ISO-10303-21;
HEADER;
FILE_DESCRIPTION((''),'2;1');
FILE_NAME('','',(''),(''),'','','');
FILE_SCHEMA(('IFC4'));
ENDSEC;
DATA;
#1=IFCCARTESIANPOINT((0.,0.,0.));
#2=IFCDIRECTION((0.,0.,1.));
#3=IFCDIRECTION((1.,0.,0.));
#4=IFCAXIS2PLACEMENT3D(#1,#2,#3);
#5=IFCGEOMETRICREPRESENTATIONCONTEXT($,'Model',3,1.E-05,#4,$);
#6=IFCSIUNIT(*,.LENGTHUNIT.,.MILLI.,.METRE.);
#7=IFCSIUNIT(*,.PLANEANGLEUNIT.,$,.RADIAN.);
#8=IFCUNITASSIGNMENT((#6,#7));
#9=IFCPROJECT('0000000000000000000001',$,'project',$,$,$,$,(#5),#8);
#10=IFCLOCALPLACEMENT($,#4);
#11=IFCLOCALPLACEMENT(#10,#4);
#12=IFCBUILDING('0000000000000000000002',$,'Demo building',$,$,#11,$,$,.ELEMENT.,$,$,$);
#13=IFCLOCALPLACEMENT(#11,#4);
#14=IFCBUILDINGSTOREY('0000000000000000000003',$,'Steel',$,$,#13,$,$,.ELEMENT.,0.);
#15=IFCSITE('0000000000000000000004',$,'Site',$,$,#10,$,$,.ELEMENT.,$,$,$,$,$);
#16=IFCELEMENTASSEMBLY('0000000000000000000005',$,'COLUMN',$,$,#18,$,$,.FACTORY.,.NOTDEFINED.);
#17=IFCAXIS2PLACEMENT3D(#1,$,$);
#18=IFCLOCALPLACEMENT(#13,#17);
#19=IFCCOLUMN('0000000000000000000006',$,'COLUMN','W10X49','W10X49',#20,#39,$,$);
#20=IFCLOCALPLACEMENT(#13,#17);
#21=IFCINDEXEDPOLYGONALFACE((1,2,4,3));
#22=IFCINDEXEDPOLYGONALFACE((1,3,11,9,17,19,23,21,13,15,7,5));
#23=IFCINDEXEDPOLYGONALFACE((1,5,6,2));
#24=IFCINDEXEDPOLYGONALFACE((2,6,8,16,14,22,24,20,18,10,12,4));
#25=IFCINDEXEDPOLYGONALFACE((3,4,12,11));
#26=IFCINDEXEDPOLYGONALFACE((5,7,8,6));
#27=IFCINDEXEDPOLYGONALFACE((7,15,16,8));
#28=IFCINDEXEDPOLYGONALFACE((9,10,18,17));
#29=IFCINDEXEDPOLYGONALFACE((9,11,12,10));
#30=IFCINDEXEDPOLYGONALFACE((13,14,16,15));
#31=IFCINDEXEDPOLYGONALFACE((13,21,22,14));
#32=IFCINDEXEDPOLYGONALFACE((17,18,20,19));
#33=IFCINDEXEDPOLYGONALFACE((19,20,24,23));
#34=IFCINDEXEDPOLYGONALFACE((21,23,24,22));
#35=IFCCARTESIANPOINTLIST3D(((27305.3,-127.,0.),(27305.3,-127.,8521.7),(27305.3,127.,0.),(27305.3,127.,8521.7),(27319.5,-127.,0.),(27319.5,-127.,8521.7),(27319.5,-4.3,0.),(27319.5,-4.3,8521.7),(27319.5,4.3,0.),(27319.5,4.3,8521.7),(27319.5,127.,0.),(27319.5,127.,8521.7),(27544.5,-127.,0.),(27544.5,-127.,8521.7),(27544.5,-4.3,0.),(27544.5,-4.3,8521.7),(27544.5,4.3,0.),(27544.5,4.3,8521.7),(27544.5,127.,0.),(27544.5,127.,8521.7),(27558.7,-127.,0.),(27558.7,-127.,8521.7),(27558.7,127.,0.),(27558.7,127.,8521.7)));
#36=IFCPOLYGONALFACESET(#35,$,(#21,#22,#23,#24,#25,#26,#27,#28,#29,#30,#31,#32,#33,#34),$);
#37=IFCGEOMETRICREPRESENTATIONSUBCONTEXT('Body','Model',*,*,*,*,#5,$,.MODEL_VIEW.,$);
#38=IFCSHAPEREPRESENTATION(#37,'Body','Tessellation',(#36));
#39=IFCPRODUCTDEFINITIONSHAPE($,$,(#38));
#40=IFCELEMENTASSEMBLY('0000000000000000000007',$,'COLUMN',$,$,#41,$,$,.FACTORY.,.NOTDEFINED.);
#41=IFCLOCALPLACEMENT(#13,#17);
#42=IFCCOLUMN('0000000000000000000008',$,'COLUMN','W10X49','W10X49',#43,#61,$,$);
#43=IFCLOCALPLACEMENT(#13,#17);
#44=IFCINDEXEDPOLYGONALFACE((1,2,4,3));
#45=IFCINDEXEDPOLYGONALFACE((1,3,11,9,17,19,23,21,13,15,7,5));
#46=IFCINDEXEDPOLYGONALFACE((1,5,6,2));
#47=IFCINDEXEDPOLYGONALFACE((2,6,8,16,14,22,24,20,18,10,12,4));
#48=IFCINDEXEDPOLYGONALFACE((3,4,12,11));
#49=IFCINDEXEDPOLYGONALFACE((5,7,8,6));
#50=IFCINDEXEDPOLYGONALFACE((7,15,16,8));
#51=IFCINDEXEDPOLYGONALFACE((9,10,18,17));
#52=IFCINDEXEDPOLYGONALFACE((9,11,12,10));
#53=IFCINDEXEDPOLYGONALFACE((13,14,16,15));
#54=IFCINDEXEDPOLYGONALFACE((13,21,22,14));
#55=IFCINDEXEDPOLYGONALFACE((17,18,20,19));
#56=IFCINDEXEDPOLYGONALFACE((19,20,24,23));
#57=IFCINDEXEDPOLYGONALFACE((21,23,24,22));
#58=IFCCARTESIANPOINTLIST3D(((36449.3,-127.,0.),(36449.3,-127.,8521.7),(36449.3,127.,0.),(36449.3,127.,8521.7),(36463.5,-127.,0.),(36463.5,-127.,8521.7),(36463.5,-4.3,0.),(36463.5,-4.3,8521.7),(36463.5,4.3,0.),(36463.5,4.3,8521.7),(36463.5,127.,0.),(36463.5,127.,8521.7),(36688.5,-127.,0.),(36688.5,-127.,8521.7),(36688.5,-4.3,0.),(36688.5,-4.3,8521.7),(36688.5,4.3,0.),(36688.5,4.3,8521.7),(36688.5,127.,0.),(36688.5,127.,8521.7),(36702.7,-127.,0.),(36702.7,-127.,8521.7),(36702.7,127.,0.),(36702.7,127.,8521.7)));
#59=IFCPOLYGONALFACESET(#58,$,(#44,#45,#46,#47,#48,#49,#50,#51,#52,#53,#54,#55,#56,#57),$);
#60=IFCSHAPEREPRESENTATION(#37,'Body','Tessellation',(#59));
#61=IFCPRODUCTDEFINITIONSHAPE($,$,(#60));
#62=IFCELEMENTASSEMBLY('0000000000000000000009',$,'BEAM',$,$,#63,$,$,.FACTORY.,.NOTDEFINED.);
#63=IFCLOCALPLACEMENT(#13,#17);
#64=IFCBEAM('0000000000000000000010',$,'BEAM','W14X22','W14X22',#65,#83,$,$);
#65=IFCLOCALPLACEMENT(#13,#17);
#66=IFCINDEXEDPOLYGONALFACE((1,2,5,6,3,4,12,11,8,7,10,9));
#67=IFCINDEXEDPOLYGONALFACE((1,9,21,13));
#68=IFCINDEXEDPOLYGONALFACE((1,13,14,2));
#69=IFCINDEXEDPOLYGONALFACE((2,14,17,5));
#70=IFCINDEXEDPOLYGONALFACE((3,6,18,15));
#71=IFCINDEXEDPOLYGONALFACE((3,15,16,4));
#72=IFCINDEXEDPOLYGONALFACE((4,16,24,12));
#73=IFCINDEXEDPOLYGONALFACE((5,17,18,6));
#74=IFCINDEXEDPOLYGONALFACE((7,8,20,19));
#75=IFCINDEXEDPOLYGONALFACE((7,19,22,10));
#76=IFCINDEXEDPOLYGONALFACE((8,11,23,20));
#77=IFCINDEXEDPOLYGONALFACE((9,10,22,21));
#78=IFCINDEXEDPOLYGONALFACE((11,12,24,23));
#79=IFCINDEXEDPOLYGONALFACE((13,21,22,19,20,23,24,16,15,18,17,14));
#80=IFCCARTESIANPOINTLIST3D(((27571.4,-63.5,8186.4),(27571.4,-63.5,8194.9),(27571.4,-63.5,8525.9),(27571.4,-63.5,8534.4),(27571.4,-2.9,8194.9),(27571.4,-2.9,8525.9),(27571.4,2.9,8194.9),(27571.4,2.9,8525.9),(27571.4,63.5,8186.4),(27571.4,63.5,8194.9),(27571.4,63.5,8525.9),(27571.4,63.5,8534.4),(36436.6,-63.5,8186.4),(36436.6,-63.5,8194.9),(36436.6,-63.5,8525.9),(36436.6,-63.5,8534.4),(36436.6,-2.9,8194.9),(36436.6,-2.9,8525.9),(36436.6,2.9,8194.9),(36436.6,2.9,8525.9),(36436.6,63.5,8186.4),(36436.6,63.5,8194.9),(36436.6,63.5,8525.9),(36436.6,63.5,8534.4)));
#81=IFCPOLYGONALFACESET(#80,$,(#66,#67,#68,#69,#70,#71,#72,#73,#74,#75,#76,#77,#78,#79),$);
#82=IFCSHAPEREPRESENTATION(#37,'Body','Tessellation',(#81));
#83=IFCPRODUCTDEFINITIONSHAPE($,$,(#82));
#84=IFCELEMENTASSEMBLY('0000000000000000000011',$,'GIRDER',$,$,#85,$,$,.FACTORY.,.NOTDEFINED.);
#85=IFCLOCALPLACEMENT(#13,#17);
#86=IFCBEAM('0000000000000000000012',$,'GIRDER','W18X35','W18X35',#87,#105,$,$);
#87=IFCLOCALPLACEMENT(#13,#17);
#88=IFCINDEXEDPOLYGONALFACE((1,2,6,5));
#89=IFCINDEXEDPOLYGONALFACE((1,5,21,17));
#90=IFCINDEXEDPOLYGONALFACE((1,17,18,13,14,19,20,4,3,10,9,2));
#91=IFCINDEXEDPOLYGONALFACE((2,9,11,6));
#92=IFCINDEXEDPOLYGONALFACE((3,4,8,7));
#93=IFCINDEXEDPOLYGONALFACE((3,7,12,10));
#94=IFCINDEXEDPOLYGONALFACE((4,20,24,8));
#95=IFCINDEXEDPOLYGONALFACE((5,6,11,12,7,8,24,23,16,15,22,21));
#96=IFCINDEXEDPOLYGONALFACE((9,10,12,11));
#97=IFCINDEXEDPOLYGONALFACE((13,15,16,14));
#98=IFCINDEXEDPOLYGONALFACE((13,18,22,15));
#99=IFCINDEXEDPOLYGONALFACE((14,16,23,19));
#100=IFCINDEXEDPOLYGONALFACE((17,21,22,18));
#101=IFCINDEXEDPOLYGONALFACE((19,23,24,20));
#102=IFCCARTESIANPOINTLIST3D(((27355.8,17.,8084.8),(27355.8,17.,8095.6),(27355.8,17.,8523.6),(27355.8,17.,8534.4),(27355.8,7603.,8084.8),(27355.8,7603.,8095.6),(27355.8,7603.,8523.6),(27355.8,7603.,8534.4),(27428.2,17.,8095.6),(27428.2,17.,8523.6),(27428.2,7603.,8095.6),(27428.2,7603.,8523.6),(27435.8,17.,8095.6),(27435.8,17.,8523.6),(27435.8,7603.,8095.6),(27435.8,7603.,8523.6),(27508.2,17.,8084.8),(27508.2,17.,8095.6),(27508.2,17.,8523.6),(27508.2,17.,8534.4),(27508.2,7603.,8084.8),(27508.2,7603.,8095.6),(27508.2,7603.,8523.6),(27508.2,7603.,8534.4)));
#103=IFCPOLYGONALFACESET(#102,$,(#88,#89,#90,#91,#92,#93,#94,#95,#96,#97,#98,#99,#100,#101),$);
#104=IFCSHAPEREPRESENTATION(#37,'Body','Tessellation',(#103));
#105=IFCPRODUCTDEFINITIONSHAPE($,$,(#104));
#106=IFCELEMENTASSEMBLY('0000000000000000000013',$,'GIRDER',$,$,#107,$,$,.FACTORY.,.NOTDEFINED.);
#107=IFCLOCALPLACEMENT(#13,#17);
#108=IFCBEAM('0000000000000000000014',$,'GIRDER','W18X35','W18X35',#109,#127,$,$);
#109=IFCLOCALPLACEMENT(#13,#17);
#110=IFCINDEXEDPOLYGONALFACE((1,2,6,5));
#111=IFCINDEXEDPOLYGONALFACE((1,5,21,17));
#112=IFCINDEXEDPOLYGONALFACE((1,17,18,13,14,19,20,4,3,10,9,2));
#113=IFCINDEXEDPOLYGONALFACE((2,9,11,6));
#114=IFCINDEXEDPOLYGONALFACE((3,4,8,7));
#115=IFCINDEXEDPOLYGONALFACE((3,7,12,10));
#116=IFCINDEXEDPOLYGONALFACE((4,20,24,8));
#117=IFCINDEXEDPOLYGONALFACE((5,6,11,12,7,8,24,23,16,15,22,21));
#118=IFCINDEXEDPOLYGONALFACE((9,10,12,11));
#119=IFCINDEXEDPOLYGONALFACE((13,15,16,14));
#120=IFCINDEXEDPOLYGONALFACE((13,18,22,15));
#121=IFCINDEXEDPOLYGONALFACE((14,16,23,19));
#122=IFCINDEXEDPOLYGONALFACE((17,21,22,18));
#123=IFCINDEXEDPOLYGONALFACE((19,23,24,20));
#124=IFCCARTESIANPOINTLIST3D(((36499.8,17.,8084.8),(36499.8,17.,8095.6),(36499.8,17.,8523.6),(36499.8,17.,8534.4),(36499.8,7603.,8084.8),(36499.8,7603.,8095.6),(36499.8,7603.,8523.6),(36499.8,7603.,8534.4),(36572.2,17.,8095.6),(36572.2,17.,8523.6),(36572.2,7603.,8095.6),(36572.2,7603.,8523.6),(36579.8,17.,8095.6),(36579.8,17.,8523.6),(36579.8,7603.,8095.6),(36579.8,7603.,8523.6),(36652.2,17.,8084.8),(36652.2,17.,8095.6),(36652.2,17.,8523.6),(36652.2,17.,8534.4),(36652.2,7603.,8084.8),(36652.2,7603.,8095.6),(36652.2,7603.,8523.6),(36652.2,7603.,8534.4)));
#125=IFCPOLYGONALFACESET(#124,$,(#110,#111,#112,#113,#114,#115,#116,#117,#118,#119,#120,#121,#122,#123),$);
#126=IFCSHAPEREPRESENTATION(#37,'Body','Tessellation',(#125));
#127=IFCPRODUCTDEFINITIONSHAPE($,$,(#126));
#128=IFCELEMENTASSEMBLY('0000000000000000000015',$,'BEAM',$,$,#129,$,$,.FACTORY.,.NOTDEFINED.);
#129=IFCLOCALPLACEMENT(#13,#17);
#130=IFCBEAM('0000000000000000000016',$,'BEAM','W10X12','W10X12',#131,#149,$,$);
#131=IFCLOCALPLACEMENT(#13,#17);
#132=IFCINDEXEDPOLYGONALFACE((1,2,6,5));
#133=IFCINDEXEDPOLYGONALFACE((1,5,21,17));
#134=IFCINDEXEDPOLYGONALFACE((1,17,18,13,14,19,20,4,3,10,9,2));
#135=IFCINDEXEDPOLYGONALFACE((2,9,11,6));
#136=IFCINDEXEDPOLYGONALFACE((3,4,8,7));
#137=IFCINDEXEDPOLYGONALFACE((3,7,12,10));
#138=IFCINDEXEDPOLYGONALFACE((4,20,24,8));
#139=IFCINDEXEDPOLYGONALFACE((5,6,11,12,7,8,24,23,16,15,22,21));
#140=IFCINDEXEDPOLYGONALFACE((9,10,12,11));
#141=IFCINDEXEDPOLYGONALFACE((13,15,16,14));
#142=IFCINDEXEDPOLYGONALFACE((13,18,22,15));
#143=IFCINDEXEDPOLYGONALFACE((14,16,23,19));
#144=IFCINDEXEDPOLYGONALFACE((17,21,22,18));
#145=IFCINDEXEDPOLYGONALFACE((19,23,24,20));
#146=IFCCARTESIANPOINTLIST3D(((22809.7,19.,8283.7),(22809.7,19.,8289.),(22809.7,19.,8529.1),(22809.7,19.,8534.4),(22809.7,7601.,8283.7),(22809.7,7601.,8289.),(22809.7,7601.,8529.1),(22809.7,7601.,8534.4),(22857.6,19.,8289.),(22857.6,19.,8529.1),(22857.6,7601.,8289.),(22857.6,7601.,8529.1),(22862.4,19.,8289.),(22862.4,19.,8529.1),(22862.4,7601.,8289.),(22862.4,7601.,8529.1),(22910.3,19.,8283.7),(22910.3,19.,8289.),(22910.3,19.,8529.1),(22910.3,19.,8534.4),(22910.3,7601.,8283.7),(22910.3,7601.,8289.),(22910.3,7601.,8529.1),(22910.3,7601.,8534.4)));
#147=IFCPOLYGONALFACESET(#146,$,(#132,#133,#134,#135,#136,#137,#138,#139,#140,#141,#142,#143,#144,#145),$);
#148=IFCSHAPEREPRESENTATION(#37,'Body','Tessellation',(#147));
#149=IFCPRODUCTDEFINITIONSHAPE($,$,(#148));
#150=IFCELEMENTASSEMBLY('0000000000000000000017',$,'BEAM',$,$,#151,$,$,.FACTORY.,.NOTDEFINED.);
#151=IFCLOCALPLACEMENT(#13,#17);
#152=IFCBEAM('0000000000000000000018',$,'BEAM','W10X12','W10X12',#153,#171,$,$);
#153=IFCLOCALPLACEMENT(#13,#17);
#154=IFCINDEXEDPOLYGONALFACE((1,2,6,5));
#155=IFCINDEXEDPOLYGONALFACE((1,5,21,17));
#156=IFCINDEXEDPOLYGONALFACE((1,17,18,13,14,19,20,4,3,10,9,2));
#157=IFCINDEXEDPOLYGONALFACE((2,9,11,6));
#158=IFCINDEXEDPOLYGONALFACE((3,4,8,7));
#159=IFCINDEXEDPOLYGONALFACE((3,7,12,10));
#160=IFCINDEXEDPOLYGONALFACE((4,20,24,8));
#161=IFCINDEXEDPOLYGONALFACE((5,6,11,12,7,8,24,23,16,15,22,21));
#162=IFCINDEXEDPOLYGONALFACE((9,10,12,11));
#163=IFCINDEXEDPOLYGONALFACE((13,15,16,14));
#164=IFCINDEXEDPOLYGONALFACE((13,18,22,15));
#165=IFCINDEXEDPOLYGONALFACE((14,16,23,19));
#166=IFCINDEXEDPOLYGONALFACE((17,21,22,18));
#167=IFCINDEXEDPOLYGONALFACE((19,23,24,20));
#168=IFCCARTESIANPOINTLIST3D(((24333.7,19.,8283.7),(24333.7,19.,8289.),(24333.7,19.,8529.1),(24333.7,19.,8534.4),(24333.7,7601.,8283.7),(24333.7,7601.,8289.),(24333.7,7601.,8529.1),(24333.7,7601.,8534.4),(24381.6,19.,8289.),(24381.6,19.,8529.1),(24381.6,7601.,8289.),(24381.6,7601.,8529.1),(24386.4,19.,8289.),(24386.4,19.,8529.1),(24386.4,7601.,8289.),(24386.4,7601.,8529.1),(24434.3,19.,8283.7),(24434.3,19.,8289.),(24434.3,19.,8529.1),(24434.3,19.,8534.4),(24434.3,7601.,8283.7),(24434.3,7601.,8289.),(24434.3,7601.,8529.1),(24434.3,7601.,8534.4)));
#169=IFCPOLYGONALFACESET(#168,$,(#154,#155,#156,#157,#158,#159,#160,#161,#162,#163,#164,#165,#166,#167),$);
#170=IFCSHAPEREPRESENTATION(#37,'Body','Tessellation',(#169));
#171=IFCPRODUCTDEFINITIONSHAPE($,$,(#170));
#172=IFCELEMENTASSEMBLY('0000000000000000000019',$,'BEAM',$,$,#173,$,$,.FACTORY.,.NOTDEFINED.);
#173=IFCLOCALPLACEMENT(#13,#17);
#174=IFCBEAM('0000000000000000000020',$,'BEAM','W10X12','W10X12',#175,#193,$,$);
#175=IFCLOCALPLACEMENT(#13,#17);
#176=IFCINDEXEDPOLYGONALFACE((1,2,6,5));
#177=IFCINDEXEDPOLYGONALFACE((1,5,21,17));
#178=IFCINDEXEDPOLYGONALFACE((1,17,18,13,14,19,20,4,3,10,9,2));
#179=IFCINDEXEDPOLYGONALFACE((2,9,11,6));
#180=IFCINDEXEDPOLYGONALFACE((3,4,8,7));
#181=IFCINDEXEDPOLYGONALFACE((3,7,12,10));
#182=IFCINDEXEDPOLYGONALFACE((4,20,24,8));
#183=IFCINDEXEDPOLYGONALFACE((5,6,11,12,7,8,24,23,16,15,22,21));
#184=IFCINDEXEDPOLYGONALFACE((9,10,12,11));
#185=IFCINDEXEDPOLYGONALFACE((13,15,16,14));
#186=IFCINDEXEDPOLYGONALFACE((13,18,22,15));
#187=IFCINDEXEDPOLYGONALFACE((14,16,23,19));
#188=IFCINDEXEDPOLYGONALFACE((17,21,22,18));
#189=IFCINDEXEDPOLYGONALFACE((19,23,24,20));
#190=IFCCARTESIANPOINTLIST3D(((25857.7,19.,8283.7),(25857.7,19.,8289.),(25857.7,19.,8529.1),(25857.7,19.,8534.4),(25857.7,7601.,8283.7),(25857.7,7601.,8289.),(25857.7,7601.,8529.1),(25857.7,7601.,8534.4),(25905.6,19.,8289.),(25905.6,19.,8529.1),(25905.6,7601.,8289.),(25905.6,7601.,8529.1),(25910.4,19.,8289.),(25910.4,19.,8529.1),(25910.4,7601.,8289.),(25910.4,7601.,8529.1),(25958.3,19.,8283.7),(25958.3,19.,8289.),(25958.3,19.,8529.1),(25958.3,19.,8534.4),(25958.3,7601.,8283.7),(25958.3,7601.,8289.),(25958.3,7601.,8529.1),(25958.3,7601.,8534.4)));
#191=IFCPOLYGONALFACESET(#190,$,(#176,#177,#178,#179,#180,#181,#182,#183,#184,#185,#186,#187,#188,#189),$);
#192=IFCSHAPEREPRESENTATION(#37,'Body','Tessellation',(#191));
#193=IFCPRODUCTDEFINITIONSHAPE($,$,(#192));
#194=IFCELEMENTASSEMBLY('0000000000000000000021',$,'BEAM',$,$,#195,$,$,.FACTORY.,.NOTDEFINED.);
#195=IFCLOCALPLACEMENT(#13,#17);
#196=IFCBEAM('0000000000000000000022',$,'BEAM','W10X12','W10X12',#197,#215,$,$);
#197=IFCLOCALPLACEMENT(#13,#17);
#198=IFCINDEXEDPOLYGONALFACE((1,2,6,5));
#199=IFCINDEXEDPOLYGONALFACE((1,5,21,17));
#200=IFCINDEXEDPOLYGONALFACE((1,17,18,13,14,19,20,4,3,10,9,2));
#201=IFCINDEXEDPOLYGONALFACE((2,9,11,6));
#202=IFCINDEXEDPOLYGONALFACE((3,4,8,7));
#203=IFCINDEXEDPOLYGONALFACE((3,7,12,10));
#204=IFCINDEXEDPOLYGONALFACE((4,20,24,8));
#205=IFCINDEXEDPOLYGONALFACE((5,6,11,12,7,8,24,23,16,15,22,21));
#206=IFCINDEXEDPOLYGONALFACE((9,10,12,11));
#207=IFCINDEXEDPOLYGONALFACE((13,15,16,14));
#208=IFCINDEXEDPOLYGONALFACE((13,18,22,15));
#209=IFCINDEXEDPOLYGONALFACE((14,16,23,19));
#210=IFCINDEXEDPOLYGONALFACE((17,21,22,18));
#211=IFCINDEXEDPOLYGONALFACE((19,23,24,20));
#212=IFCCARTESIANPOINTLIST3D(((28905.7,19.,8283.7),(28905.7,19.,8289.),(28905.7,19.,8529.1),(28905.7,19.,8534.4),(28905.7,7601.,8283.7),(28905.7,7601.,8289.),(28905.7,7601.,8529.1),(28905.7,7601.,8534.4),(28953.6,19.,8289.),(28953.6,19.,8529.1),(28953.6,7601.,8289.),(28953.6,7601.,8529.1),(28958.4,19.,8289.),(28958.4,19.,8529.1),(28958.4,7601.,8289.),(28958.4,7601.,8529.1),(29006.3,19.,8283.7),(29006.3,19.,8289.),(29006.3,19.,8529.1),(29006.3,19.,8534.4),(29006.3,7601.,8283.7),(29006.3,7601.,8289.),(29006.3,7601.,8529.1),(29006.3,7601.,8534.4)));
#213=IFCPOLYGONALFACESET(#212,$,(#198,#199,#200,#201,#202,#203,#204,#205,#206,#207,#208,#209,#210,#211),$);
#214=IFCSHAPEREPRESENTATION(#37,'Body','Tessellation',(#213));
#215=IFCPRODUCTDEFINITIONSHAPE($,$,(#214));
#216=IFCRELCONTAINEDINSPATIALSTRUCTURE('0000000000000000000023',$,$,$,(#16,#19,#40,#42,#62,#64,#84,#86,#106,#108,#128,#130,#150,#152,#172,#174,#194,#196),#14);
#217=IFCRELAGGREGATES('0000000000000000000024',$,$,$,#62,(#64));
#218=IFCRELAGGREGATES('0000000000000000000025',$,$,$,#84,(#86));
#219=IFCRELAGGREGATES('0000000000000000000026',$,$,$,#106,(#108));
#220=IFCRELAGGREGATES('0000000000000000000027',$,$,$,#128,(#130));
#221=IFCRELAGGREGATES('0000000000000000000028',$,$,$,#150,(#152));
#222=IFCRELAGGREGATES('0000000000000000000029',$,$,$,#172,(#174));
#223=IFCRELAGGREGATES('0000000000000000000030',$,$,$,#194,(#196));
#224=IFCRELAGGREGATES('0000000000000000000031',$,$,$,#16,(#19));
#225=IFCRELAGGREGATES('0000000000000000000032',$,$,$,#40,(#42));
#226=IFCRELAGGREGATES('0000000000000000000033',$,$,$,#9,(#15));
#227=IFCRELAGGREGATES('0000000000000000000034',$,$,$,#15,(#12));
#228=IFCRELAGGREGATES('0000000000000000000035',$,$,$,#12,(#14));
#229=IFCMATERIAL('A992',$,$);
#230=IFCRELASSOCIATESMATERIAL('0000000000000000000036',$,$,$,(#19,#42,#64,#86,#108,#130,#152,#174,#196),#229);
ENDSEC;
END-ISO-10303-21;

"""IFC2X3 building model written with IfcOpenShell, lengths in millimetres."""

from ifc_helpers import new_model, si_unit, frame, origin, origin_with_axes, origin_2d, place, context, subcontext, project, spatial, i_section, extrude, material, element, aggregate, save


model = new_model("IFC2X3")

# Units and contexts
model_context = context("Model", 3, precision=1e-05, world=origin_with_axes())
body_context = subcontext(model_context, "Body", "Model", "MODEL_VIEW")
ifc_project = project(units=[si_unit("LENGTHUNIT", "METRE", prefix="MILLI"), si_unit("PLANEANGLEUNIT", "RADIAN")], contexts=[model_context])

# Site, building, storey
site_placement = place(None, origin_with_axes())
site = spatial("IfcSite", under=ifc_project, at=site_placement, Name="Site", CompositionType="ELEMENT")
building_placement = place(site_placement, origin_with_axes())
building = spatial("IfcBuilding", under=site, at=building_placement, Name="Demo building", CompositionType="ELEMENT")
placement = place(building_placement, origin_with_axes())
storey = spatial("IfcBuildingStorey", under=building, at=placement, Name="Steel", CompositionType="ELEMENT", Elevation=0.0)

# Element assemblies, columns
assembly_1 = element("IfcElementAssembly", 1, at=placement, inside=storey, Name="COLUMN", AssemblyPlace="FACTORY", PredefinedType="NOTDEFINED")
ifc_material_1 = material(Name="A992")
column_1_placement = place(placement, frame((27432.0, 0.0, 0.0), z_axis=(0.0, 0.0, 1.0), x_axis=(0.0, -1.0, 0.0)))
column_1 = element("IfcColumn", 2, at=column_1_placement, inside=storey, material=ifc_material_1, Name="COLUMN", Description="W10X49", ObjectType="W10X49", context=body_context, shape_type="SweptSolid", body=[
    extrude(i_section(OverallWidth=254.0, OverallDepth=253.5, WebThickness=8.6, FlangeThickness=14.2, at=origin_2d()), origin(), (0.0, 0.0, 1.0), 8521.7),
])
assembly_2 = element("IfcElementAssembly", 3, at=placement, inside=storey, Name="COLUMN", AssemblyPlace="FACTORY", PredefinedType="NOTDEFINED")
column_2_placement = place(placement, frame((36576.0, 0.0, 0.0), z_axis=(0.0, 0.0, 1.0), x_axis=(0.0, -1.0, 0.0)))
column_2 = element("IfcColumn", 4, at=column_2_placement, inside=storey, material=ifc_material_1, Name="COLUMN", Description="W10X49", ObjectType="W10X49", context=body_context, shape_type="SweptSolid", body=[
    extrude(i_section(OverallWidth=254.0, OverallDepth=253.5, WebThickness=8.6, FlangeThickness=14.2, at=origin_2d()), origin(), (0.0, 0.0, 1.0), 8521.7),
])

# Element assemblies, beams
assembly_3 = element("IfcElementAssembly", 5, at=placement, inside=storey, Name="BEAM", AssemblyPlace="FACTORY", PredefinedType="NOTDEFINED")
beam_1_placement = place(placement, frame((27571.4, 0.0, 8360.4), z_axis=(1.0, 0.0, 0.0), x_axis=(0.0, 1.0, 0.0)))
beam_1 = element("IfcBeam", 6, at=beam_1_placement, inside=storey, material=ifc_material_1, Name="BEAM", Description="W14X22", ObjectType="W14X22", context=body_context, shape_type="SweptSolid", body=[
    extrude(i_section(OverallWidth=127.0, OverallDepth=348.0, WebThickness=5.8, FlangeThickness=8.5, at=origin_2d()), origin(), (0.0, 0.0, 1.0), 8865.1),
])
aggregate(assembly_3, [beam_1])
assembly_4 = element("IfcElementAssembly", 7, at=placement, inside=storey, Name="GIRDER", AssemblyPlace="FACTORY", PredefinedType="NOTDEFINED")
beam_2_placement = place(placement, frame((27432.0, 17.0, 8309.6), z_axis=(0.0, 1.0, 0.0), x_axis=(-1.0, 0.0, 0.0)))
beam_2 = element("IfcBeam", 8, at=beam_2_placement, inside=storey, material=ifc_material_1, Name="GIRDER", Description="W18X35", ObjectType="W18X35", context=body_context, shape_type="SweptSolid", body=[
    extrude(i_section(OverallWidth=152.4, OverallDepth=449.6, WebThickness=7.6, FlangeThickness=10.8, at=origin_2d()), origin(), (0.0, 0.0, 1.0), 7586.0),
])
aggregate(assembly_4, [beam_2])
assembly_5 = element("IfcElementAssembly", 9, at=placement, inside=storey, Name="GIRDER", AssemblyPlace="FACTORY", PredefinedType="NOTDEFINED")
beam_3_placement = place(placement, frame((36576.0, 17.0, 8309.6), z_axis=(0.0, 1.0, 0.0), x_axis=(-1.0, 0.0, 0.0)))
beam_3 = element("IfcBeam", 10, at=beam_3_placement, inside=storey, material=ifc_material_1, Name="GIRDER", Description="W18X35", ObjectType="W18X35", context=body_context, shape_type="SweptSolid", body=[
    extrude(i_section(OverallWidth=152.4, OverallDepth=449.6, WebThickness=7.6, FlangeThickness=10.8, at=origin_2d()), origin(), (0.0, 0.0, 1.0), 7586.0),
])
aggregate(assembly_5, [beam_3])
assembly_6 = element("IfcElementAssembly", 11, at=placement, inside=storey, Name="BEAM", AssemblyPlace="FACTORY", PredefinedType="NOTDEFINED")
beam_4_placement = place(placement, frame((22860.0, 19.1, 8409.1), z_axis=(0.0, 1.0, 0.0), x_axis=(-1.0, 0.0, 0.0)))
beam_4 = element("IfcBeam", 12, at=beam_4_placement, inside=storey, material=ifc_material_1, Name="BEAM", Description="W10X12", ObjectType="W10X12", context=body_context, shape_type="SweptSolid", body=[
    extrude(i_section(OverallWidth=100.6, OverallDepth=250.7, WebThickness=4.8, FlangeThickness=5.3, at=origin_2d()), origin(), (0.0, 0.0, 1.0), 7581.9),
])
aggregate(assembly_6, [beam_4])
assembly_7 = element("IfcElementAssembly", 13, at=placement, inside=storey, Name="BEAM", AssemblyPlace="FACTORY", PredefinedType="NOTDEFINED")
beam_5_placement = place(placement, frame((24384.0, 19.1, 8409.1), z_axis=(0.0, 1.0, 0.0), x_axis=(-1.0, 0.0, 0.0)))
beam_5 = element("IfcBeam", 14, at=beam_5_placement, inside=storey, material=ifc_material_1, Name="BEAM", Description="W10X12", ObjectType="W10X12", context=body_context, shape_type="SweptSolid", body=[
    extrude(i_section(OverallWidth=100.6, OverallDepth=250.7, WebThickness=4.8, FlangeThickness=5.3, at=origin_2d()), origin(), (0.0, 0.0, 1.0), 7581.9),
])
aggregate(assembly_7, [beam_5])
assembly_8 = element("IfcElementAssembly", 15, at=placement, inside=storey, Name="BEAM", AssemblyPlace="FACTORY", PredefinedType="NOTDEFINED")
beam_6_placement = place(placement, frame((25908.0, 19.1, 8409.1), z_axis=(0.0, 1.0, 0.0), x_axis=(-1.0, 0.0, 0.0)))
beam_6 = element("IfcBeam", 16, at=beam_6_placement, inside=storey, material=ifc_material_1, Name="BEAM", Description="W10X12", ObjectType="W10X12", context=body_context, shape_type="SweptSolid", body=[
    extrude(i_section(OverallWidth=100.6, OverallDepth=250.7, WebThickness=4.8, FlangeThickness=5.3, at=origin_2d()), origin(), (0.0, 0.0, 1.0), 7581.9),
])
aggregate(assembly_8, [beam_6])
assembly_9 = element("IfcElementAssembly", 17, at=placement, inside=storey, Name="BEAM", AssemblyPlace="FACTORY", PredefinedType="NOTDEFINED")
beam_7_placement = place(placement, frame((28956.0, 19.1, 8409.1), z_axis=(0.0, 1.0, 0.0), x_axis=(-1.0, 0.0, 0.0)))
beam_7 = element("IfcBeam", 18, at=beam_7_placement, inside=storey, material=ifc_material_1, Name="BEAM", Description="W10X12", ObjectType="W10X12", context=body_context, shape_type="SweptSolid", body=[
    extrude(i_section(OverallWidth=100.6, OverallDepth=250.7, WebThickness=4.8, FlangeThickness=5.3, at=origin_2d()), origin(), (0.0, 0.0, 1.0), 7581.9),
])
aggregate(assembly_9, [beam_7])

aggregate(assembly_1, [column_1])

aggregate(assembly_2, [column_2])

save(model, "model.ifc")
